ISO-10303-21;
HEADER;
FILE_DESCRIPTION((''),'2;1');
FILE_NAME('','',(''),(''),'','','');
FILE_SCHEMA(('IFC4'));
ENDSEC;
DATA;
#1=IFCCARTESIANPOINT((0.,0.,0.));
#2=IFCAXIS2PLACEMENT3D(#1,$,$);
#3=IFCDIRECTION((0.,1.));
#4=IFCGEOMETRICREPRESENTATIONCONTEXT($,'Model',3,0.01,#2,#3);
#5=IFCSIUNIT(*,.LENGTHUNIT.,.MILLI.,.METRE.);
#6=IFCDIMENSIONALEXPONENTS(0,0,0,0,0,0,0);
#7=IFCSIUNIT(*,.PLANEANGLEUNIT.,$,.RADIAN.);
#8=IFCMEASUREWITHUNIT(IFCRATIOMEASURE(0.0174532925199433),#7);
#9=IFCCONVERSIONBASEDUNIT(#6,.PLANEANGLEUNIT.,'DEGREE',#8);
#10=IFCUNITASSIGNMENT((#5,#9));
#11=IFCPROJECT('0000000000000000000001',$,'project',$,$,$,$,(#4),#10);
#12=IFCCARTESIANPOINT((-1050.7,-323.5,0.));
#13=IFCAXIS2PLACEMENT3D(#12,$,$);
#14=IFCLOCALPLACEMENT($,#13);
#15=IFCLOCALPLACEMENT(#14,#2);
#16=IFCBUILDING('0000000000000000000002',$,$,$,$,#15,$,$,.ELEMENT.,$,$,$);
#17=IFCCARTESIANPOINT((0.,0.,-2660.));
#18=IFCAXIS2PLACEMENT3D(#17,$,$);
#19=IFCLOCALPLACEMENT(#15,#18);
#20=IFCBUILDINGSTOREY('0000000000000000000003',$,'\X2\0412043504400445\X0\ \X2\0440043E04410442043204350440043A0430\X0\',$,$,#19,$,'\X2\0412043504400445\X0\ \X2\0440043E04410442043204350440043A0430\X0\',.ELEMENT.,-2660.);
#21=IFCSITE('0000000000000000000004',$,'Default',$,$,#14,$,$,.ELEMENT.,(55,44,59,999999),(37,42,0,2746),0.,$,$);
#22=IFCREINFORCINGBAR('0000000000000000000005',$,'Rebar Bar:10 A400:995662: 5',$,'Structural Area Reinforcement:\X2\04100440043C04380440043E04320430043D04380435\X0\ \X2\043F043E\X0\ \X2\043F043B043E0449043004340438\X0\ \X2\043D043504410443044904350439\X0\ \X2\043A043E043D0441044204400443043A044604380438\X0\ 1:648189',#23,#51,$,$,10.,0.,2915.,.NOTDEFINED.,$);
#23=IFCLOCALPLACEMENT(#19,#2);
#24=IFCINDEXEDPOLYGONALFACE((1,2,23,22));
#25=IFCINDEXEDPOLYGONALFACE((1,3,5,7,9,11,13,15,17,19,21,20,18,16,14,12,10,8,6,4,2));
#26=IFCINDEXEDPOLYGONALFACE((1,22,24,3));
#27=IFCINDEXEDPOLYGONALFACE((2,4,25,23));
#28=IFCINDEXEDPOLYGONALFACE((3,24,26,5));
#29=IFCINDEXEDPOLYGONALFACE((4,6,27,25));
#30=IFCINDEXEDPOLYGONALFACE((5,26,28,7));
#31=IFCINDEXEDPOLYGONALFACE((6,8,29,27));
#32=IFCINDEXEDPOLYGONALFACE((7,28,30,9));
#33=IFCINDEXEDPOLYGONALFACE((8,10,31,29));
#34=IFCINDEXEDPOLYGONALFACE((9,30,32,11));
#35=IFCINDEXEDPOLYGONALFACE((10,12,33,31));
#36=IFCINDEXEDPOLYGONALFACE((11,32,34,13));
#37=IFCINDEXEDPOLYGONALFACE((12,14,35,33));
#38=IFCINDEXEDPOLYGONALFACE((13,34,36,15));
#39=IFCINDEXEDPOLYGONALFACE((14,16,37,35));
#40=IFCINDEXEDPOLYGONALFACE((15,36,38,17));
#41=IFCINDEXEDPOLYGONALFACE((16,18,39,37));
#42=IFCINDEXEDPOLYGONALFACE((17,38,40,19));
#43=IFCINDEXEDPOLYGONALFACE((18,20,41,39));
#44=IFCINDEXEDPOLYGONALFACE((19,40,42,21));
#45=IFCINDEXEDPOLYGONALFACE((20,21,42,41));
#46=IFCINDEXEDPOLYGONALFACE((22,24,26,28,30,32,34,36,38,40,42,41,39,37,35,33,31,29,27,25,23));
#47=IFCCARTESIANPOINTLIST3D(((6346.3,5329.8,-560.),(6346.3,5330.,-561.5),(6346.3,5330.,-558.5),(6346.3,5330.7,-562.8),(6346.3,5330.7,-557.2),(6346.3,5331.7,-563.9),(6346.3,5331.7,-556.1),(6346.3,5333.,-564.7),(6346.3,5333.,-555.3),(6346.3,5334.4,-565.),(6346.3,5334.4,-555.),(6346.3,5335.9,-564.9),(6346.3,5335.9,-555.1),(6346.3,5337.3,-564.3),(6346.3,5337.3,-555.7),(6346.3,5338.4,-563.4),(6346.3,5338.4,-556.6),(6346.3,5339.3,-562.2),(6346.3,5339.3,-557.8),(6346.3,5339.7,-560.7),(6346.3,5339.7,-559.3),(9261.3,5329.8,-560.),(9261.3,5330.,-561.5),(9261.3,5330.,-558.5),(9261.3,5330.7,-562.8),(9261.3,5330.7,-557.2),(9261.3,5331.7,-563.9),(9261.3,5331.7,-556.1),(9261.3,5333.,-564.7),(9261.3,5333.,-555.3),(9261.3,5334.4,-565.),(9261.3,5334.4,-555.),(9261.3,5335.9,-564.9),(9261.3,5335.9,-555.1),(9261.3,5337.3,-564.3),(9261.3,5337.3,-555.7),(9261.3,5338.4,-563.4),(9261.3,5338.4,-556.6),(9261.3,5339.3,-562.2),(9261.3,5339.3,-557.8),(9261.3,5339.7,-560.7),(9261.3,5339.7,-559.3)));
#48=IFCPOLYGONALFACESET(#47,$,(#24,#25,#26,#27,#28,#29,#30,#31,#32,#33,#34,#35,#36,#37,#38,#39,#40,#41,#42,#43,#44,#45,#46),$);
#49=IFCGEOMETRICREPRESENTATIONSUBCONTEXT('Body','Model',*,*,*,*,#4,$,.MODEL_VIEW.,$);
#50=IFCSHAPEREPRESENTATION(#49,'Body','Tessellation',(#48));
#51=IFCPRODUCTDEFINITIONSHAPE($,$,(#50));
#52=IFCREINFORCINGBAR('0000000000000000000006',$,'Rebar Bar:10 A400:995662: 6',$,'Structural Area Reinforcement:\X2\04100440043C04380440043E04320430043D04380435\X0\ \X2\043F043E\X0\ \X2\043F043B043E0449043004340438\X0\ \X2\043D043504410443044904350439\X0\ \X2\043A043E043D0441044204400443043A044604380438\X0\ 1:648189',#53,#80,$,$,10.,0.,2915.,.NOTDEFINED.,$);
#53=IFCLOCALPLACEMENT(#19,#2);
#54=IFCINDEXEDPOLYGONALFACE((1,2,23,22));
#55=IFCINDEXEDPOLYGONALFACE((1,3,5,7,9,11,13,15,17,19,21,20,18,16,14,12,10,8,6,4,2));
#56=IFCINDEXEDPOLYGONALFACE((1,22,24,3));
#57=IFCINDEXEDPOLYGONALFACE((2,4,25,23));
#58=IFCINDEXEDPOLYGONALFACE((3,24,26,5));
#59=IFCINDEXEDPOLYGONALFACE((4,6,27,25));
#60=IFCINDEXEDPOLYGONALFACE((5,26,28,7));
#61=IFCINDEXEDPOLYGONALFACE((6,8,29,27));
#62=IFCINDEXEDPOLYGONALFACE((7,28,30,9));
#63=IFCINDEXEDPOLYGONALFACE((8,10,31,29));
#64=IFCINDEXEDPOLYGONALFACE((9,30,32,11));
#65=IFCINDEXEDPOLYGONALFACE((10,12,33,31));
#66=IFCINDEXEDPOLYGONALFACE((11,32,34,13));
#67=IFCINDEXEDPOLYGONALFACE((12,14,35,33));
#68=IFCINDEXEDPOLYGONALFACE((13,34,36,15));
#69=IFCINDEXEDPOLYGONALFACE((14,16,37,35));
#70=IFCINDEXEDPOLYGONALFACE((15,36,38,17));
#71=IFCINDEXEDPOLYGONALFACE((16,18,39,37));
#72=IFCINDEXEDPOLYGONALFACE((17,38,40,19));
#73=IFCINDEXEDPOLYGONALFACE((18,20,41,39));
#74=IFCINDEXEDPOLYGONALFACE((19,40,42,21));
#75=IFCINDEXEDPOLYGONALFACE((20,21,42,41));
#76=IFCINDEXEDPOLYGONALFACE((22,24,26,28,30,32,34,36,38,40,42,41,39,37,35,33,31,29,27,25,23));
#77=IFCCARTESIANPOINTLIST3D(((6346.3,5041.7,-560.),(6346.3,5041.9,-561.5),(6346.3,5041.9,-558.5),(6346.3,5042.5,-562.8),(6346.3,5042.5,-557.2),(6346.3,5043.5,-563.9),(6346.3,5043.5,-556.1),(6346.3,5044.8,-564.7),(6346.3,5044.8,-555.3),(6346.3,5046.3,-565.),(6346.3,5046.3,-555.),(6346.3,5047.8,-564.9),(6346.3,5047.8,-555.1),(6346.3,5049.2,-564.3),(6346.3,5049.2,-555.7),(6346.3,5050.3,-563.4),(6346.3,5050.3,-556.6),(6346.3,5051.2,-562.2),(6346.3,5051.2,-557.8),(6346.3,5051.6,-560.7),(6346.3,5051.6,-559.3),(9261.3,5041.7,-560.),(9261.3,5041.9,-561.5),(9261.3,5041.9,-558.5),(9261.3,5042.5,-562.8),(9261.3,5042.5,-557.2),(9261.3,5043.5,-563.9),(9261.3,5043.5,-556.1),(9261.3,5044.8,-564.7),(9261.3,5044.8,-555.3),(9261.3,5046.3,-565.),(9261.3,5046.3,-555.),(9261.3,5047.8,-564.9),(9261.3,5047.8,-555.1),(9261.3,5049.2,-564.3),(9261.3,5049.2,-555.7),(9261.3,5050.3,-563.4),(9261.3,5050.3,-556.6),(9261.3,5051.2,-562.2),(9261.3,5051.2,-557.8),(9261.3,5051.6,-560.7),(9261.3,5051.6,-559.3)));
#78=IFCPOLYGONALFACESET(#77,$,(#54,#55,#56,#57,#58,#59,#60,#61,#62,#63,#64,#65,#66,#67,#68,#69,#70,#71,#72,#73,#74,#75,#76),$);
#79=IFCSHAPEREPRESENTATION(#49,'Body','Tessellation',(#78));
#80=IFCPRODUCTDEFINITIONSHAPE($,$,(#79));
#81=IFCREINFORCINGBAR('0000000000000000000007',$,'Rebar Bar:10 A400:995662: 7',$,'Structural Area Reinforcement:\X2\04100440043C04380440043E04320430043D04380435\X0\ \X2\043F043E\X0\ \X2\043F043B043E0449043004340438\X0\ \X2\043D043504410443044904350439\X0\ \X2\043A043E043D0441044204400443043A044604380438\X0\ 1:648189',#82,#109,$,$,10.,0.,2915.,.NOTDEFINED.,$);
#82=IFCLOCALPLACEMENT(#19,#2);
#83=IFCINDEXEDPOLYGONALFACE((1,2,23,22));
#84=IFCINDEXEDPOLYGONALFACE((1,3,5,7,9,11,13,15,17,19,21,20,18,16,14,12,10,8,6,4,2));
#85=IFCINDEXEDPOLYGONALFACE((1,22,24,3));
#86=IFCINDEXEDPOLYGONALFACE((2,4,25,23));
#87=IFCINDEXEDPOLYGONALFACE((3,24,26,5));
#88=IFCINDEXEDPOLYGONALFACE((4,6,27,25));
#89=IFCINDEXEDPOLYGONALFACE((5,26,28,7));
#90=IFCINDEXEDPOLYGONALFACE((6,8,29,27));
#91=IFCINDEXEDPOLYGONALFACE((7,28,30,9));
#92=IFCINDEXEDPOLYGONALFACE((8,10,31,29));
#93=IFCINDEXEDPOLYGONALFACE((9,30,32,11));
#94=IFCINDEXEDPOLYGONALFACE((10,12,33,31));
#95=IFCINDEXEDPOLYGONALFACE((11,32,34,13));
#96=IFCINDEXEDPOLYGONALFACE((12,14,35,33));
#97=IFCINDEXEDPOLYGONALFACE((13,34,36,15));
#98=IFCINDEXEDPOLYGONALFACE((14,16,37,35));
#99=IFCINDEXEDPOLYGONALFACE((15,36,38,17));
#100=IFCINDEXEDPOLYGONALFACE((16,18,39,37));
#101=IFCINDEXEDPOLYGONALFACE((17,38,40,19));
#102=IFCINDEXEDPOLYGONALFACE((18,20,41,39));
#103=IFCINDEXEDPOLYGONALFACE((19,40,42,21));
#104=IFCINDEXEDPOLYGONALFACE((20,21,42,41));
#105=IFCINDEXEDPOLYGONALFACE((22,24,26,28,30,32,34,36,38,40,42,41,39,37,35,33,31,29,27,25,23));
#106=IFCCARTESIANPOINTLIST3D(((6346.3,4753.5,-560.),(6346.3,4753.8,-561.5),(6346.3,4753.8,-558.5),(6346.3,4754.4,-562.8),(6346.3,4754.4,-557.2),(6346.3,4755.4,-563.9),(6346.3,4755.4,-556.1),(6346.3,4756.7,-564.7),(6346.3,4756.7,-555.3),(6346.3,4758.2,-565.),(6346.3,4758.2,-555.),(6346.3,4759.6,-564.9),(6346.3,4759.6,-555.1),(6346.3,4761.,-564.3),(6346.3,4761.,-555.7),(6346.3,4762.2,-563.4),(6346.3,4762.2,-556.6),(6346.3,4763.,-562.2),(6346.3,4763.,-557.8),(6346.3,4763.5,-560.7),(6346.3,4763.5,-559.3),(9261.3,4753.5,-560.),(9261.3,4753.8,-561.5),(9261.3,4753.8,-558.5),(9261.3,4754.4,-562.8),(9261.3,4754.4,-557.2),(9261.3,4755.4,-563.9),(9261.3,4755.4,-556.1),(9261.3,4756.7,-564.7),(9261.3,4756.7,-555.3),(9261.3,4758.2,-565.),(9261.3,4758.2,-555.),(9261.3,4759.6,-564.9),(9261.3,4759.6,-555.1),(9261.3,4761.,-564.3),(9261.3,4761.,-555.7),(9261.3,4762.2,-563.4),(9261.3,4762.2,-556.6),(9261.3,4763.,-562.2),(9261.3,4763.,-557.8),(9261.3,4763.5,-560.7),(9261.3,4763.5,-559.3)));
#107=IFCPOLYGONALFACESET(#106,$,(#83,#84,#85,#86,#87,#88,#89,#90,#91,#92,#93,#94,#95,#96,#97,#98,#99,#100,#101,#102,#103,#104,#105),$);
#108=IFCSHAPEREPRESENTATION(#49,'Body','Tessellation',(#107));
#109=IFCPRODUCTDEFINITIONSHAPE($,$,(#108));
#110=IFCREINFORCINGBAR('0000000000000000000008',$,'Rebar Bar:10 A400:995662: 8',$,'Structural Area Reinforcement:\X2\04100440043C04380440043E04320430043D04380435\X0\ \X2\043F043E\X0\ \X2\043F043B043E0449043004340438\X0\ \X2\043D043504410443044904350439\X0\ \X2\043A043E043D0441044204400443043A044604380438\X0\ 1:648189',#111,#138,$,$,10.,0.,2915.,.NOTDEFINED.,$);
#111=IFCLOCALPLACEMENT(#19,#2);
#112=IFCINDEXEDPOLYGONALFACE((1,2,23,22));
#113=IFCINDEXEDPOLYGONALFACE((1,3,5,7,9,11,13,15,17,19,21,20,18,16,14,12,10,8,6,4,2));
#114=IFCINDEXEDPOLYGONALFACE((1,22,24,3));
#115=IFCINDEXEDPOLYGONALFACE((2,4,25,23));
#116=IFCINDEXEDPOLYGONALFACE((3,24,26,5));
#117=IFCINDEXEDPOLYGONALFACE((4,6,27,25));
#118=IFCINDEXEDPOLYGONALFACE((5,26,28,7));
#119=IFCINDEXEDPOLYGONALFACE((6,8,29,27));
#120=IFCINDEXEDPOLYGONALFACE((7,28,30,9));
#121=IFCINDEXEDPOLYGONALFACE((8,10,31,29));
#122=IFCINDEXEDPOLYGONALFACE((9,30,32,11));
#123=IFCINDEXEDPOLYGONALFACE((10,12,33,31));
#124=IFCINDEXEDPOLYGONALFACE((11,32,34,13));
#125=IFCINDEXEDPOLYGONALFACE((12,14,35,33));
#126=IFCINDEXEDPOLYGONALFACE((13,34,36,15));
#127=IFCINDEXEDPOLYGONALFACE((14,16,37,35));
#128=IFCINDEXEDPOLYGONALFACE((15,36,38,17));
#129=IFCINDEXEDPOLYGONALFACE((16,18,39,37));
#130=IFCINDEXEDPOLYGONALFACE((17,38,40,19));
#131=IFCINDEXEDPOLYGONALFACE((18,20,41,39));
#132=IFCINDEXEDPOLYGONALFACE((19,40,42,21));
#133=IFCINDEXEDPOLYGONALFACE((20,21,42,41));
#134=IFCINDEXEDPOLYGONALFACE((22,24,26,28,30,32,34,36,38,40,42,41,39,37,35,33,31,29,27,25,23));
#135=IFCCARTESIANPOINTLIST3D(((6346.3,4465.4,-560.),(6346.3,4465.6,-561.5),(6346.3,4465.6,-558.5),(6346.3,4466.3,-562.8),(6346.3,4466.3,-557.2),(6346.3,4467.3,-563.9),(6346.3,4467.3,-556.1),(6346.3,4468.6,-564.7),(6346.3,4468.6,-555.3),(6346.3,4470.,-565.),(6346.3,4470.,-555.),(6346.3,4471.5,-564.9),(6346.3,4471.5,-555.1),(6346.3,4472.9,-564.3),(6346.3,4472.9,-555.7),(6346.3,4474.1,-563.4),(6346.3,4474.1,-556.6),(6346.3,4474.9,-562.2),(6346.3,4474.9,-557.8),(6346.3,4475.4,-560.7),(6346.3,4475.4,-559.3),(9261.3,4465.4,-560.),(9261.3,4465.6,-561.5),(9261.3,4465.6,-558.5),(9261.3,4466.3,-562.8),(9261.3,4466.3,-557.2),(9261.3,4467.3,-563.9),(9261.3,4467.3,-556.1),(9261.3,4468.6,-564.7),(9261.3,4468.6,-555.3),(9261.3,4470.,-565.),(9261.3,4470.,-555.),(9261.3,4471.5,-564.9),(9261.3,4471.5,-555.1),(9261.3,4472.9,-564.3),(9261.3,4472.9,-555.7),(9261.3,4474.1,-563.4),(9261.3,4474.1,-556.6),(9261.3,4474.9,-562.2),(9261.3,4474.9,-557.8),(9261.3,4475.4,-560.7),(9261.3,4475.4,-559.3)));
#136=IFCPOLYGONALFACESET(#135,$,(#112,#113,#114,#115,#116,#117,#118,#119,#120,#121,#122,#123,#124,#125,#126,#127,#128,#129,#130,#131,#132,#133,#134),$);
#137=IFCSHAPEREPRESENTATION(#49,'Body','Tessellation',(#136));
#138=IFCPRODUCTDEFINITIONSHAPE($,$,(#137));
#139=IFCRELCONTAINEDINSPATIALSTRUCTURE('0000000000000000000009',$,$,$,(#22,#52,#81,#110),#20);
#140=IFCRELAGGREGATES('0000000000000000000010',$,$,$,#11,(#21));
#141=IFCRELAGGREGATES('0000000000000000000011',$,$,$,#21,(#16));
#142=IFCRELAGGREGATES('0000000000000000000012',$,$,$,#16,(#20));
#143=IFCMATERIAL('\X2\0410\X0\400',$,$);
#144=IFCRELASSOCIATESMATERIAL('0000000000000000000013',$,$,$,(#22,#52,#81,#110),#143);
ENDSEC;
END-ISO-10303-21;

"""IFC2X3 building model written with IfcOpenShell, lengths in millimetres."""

from ifc_helpers import new_model, entity, si_unit, converted_unit, direction, frame, origin, place, context, subcontext, project, spatial, material, element, save


model = new_model("IFC2X3")

# Units and contexts
model_context = context("Model", 3, precision=0.01, world=origin(), true_north=direction((0.0, 1.0)))
body_context = subcontext(model_context, "Body", "Model", "MODEL_VIEW")
ifc_project = project(units=[si_unit("LENGTHUNIT", "METRE", prefix="MILLI"), converted_unit("PLANEANGLEUNIT", "DEGREE", entity("IfcRatioMeasure", 0.0174532925199433), si_unit("PLANEANGLEUNIT", "RADIAN"), dimensions=[0, 0, 0, 0, 0, 0, 0])], contexts=[model_context])

# Site, building, storey
site_placement = place(None, frame((-1050.7, -323.5, 0.0)))
site = spatial("IfcSite", under=ifc_project, at=site_placement, Name="Default", CompositionType="ELEMENT", RefLatitude=(55, 44, 59, 999999), RefLongitude=(37, 42, 0, 2746), RefElevation=0.0)
building_placement = place(site_placement, origin())
building = spatial("IfcBuilding", under=site, at=building_placement, CompositionType="ELEMENT")
storey_placement = place(building_placement, frame((0.0, 0.0, -2660.0)))
storey = spatial("IfcBuildingStorey", under=building, at=storey_placement, Name="Верх ростверка", LongName="Верх ростверка", CompositionType="ELEMENT", Elevation=-2660.0)

# Reinforcing bars
ifc_material = material(Name="А400")
reinforcing_bar_1_placement = place(storey_placement, origin())
element("IfcReinforcingBar", 1, at=reinforcing_bar_1_placement, inside=storey, material=ifc_material, Name="Rebar Bar:10 A400:995662: 5", ObjectType="Structural Area Reinforcement:Армирование по площади несущей конструкции 1:648189", BarLength=2915.0, BarRole="NOTDEFINED", CrossSectionArea=0.0, NominalDiameter=10.0, context=body_context, shape_type="AdvancedSweptSolid", body=[
    entity("IfcSweptDiskSolid", entity("IfcCompositeCurve", [entity("IfcCompositeCurveSegment", "CONTINUOUS", True, entity("IfcPolyline", [entity("IfcCartesianPoint", [9261.3, 5334.8, -560.0]), entity("IfcCartesianPoint", [6346.3, 5334.8, -560.0])]))], False), 5.0, None, 0.0, 1.0),
])
reinforcing_bar_2_placement = place(storey_placement, origin())
element("IfcReinforcingBar", 2, at=reinforcing_bar_2_placement, inside=storey, material=ifc_material, Name="Rebar Bar:10 A400:995662: 6", ObjectType="Structural Area Reinforcement:Армирование по площади несущей конструкции 1:648189", BarLength=2915.0, BarRole="NOTDEFINED", CrossSectionArea=0.0, NominalDiameter=10.0, context=body_context, shape_type="AdvancedSweptSolid", body=[
    entity("IfcSweptDiskSolid", entity("IfcCompositeCurve", [entity("IfcCompositeCurveSegment", "CONTINUOUS", True, entity("IfcPolyline", [entity("IfcCartesianPoint", [9261.3, 5046.7, -560.0]), entity("IfcCartesianPoint", [6346.3, 5046.7, -560.0])]))], False), 5.0, None, 0.0, 1.0),
])
reinforcing_bar_3_placement = place(storey_placement, origin())
element("IfcReinforcingBar", 3, at=reinforcing_bar_3_placement, inside=storey, material=ifc_material, Name="Rebar Bar:10 A400:995662: 7", ObjectType="Structural Area Reinforcement:Армирование по площади несущей конструкции 1:648189", BarLength=2915.0, BarRole="NOTDEFINED", CrossSectionArea=0.0, NominalDiameter=10.0, context=body_context, shape_type="AdvancedSweptSolid", body=[
    entity("IfcSweptDiskSolid", entity("IfcCompositeCurve", [entity("IfcCompositeCurveSegment", "CONTINUOUS", True, entity("IfcPolyline", [entity("IfcCartesianPoint", [9261.3, 4758.5, -560.0]), entity("IfcCartesianPoint", [6346.3, 4758.5, -560.0])]))], False), 5.0, None, 0.0, 1.0),
])
reinforcing_bar_4_placement = place(storey_placement, origin())
element("IfcReinforcingBar", 4, at=reinforcing_bar_4_placement, inside=storey, material=ifc_material, Name="Rebar Bar:10 A400:995662: 8", ObjectType="Structural Area Reinforcement:Армирование по площади несущей конструкции 1:648189", BarLength=2915.0, BarRole="NOTDEFINED", CrossSectionArea=0.0, NominalDiameter=10.0, context=body_context, shape_type="AdvancedSweptSolid", body=[
    entity("IfcSweptDiskSolid", entity("IfcCompositeCurve", [entity("IfcCompositeCurveSegment", "CONTINUOUS", True, entity("IfcPolyline", [entity("IfcCartesianPoint", [9261.3, 4470.4, -560.0]), entity("IfcCartesianPoint", [6346.3, 4470.4, -560.0])]))], False), 5.0, None, 0.0, 1.0),
])

save(model, "model.ifc")
